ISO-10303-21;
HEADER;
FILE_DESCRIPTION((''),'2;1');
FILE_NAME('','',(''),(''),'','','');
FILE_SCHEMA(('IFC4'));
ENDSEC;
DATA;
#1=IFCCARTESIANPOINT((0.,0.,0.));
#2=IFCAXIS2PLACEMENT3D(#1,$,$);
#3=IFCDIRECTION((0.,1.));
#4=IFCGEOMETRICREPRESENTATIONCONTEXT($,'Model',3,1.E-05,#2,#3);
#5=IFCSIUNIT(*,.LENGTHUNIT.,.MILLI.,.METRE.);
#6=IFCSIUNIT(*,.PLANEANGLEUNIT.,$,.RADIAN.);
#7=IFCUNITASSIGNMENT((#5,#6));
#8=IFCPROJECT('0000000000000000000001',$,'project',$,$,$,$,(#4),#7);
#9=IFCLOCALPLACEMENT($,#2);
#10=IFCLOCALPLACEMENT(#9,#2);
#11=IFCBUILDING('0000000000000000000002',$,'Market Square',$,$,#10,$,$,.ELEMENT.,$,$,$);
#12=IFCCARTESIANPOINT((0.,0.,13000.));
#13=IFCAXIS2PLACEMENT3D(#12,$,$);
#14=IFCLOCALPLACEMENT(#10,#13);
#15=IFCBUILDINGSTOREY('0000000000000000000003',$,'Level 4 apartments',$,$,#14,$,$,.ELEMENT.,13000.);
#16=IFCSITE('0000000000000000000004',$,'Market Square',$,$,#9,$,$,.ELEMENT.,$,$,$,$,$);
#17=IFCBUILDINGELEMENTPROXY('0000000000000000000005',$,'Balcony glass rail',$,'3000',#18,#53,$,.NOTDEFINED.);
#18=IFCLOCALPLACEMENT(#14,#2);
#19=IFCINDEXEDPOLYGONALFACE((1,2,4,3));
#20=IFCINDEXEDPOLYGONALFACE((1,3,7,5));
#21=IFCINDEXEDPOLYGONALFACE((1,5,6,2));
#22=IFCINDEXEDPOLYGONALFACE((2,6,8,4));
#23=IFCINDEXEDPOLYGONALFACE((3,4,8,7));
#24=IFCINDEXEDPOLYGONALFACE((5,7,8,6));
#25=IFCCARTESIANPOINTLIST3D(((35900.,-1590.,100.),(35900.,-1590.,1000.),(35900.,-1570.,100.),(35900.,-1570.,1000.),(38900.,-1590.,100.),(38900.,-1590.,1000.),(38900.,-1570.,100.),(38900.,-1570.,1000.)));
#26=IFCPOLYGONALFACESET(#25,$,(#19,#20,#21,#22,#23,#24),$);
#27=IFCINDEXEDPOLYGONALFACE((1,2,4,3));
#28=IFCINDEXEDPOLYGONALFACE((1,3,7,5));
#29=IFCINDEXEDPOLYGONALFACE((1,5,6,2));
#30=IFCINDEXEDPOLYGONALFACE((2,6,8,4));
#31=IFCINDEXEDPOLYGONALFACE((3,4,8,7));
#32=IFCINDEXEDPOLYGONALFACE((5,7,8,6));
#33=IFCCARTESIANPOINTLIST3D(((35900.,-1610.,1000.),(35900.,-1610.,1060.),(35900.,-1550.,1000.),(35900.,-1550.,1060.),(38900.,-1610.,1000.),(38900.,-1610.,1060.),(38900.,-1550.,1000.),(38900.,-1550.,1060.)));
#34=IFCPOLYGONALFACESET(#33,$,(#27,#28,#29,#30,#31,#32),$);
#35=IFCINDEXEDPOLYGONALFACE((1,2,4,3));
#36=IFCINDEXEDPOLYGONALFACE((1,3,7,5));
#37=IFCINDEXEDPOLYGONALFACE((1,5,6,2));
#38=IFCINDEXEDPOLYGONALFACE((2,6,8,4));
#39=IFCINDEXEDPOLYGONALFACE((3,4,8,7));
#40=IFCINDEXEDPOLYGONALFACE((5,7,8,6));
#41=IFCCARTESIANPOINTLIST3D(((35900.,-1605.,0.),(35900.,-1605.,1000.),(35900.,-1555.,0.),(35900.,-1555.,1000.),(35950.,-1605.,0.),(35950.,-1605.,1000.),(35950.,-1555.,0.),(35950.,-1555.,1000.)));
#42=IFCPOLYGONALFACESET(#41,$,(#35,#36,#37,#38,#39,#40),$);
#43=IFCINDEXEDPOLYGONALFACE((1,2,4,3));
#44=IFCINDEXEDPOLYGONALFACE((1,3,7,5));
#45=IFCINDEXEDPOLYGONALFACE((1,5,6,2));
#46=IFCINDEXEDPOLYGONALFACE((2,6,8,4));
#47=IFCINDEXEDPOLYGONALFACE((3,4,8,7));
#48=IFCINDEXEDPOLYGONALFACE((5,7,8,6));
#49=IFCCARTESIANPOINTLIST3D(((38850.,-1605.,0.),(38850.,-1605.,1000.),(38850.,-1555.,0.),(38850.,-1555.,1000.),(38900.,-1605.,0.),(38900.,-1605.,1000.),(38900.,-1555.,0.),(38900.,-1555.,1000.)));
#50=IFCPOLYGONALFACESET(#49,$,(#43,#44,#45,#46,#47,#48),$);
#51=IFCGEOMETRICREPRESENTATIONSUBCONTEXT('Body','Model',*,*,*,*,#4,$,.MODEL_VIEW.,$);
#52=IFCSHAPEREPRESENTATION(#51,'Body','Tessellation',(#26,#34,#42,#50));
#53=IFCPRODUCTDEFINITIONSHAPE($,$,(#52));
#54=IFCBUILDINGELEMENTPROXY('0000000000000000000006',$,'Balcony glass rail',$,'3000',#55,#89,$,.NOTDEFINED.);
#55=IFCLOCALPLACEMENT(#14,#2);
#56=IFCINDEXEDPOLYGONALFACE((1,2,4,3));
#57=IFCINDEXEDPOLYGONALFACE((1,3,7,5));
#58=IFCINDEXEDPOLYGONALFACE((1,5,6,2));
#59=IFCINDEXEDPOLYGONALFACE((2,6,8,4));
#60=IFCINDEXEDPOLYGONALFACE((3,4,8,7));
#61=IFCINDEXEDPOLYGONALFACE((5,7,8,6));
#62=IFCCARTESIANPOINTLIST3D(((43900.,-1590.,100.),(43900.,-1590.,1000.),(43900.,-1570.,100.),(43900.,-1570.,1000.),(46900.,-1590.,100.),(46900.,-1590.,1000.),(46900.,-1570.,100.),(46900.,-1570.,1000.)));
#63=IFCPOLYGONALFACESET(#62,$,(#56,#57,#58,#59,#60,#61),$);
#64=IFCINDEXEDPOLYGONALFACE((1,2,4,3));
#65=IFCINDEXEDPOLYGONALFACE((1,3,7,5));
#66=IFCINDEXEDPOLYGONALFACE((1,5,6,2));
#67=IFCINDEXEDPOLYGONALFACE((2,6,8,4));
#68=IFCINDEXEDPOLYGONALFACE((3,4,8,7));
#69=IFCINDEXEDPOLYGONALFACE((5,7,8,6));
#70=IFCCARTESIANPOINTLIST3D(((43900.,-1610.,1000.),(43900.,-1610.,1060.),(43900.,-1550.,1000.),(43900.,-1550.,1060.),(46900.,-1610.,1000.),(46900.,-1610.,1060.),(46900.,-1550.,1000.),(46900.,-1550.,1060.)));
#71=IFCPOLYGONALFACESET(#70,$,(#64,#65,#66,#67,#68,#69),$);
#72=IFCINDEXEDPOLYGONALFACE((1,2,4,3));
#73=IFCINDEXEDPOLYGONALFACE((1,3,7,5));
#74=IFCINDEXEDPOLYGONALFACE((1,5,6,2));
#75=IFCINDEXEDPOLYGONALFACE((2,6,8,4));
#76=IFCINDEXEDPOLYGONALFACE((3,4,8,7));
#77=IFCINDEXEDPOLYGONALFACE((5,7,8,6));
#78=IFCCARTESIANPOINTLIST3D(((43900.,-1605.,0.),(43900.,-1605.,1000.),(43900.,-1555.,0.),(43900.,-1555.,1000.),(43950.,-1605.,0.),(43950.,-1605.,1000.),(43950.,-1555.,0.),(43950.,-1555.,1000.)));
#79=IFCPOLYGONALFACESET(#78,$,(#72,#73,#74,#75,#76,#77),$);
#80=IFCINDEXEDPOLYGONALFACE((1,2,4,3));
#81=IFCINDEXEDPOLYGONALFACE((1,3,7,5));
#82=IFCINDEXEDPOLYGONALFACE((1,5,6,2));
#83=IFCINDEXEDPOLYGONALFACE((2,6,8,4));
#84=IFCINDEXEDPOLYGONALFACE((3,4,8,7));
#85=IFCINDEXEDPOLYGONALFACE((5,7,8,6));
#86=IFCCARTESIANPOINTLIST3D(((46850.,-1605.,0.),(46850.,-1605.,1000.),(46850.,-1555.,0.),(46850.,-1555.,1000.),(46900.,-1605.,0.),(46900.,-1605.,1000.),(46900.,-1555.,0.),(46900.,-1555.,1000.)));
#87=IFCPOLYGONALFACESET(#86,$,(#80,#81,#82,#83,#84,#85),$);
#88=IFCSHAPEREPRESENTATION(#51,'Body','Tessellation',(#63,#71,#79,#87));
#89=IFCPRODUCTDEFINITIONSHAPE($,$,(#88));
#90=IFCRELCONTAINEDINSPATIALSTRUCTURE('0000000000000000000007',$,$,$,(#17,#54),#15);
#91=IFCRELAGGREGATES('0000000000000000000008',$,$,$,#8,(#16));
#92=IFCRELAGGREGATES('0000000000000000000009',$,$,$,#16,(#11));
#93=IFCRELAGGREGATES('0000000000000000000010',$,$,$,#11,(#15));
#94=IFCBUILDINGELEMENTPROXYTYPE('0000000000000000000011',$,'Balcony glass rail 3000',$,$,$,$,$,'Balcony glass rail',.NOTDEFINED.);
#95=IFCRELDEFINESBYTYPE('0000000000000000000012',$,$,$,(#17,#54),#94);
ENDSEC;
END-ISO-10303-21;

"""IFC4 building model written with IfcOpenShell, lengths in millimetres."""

from ifc_helpers import new_model, si_unit, direction, frame, origin, place, context, subcontext, project, spatial, polyline, outline, extrude, source, transform, mapped, type_object, type_shapes, element, save


model = new_model("IFC4")

# Units and contexts
model_context = context("Model", 3, precision=1e-05, world=origin(), true_north=direction((0.0, 1.0)))
body_context = subcontext(model_context, "Body", "Model", "MODEL_VIEW")
ifc_project = project(units=[si_unit("LENGTHUNIT", "METRE", prefix="MILLI"), si_unit("PLANEANGLEUNIT", "RADIAN")], contexts=[model_context])

# Site, building, storey
site_placement = place(None, origin())
site = spatial("IfcSite", under=ifc_project, at=site_placement, Name="Market Square", CompositionType="ELEMENT")
building_placement = place(site_placement, origin())
building = spatial("IfcBuilding", under=site, at=building_placement, Name="Market Square", CompositionType="ELEMENT")
storey_placement = place(building_placement, frame((0.0, 0.0, 13000.0)))
storey = spatial("IfcBuildingStorey", under=building, at=storey_placement, Name="Level 4 apartments", CompositionType="ELEMENT", Elevation=13000.0)

# Building element proxies
building_element_proxy_type = type_object("IfcBuildingElementProxyType", Name="Balcony glass rail 3000", ElementType="Balcony glass rail", PredefinedType="NOTDEFINED")
shared_shape = source(origin(), body_context, "Body", "SweptSolid", [
    extrude(outline(polyline([(0.0, -10.0), (3000.0, -10.0), (3000.0, 10.0), (0.0, 10.0), (0.0, -10.0)])), frame((0.0, 0.0, 100.0)), (0.0, 0.0, 1.0), 900.0),
    extrude(outline(polyline([(0.0, -30.0), (3000.0, -30.0), (3000.0, 30.0), (0.0, 30.0), (0.0, -30.0)])), frame((0.0, 0.0, 1000.0)), (0.0, 0.0, 1.0), 60.0),
    extrude(outline(polyline([(0.0, -25.0), (50.0, -25.0), (50.0, 25.0), (0.0, 25.0), (0.0, -25.0)])), origin(), (0.0, 0.0, 1.0), 1000.0),
    extrude(outline(polyline([(2950.0, -25.0), (3000.0, -25.0), (3000.0, 25.0), (2950.0, 25.0), (2950.0, -25.0)])), origin(), (0.0, 0.0, 1.0), 1000.0),
])
type_shapes(building_element_proxy_type, [shared_shape])
for number, where, z_axis, x_axis, name in (
    (1, (35900.0, -1580.0, 0.0), (0.0, 0.0, 1.0), (1.0, 0.0, 0.0), "Balcony glass rail"),
    (2, (43900.0, -1580.0, 0.0), (0.0, 0.0, 1.0), (1.0, 0.0, 0.0), "Balcony glass rail"),
):
    element("IfcBuildingElementProxy", number, at=place(storey_placement, frame(where, z_axis=z_axis, x_axis=x_axis)), inside=storey, type_object=building_element_proxy_type, Name=name, ObjectType="3000", PredefinedType="NOTDEFINED", context=body_context, shape_type="MappedRepresentation", body=[
        mapped(shared_shape, transform((0.0, 0.0, 0.0))),
    ])

save(model, "model.ifc")
